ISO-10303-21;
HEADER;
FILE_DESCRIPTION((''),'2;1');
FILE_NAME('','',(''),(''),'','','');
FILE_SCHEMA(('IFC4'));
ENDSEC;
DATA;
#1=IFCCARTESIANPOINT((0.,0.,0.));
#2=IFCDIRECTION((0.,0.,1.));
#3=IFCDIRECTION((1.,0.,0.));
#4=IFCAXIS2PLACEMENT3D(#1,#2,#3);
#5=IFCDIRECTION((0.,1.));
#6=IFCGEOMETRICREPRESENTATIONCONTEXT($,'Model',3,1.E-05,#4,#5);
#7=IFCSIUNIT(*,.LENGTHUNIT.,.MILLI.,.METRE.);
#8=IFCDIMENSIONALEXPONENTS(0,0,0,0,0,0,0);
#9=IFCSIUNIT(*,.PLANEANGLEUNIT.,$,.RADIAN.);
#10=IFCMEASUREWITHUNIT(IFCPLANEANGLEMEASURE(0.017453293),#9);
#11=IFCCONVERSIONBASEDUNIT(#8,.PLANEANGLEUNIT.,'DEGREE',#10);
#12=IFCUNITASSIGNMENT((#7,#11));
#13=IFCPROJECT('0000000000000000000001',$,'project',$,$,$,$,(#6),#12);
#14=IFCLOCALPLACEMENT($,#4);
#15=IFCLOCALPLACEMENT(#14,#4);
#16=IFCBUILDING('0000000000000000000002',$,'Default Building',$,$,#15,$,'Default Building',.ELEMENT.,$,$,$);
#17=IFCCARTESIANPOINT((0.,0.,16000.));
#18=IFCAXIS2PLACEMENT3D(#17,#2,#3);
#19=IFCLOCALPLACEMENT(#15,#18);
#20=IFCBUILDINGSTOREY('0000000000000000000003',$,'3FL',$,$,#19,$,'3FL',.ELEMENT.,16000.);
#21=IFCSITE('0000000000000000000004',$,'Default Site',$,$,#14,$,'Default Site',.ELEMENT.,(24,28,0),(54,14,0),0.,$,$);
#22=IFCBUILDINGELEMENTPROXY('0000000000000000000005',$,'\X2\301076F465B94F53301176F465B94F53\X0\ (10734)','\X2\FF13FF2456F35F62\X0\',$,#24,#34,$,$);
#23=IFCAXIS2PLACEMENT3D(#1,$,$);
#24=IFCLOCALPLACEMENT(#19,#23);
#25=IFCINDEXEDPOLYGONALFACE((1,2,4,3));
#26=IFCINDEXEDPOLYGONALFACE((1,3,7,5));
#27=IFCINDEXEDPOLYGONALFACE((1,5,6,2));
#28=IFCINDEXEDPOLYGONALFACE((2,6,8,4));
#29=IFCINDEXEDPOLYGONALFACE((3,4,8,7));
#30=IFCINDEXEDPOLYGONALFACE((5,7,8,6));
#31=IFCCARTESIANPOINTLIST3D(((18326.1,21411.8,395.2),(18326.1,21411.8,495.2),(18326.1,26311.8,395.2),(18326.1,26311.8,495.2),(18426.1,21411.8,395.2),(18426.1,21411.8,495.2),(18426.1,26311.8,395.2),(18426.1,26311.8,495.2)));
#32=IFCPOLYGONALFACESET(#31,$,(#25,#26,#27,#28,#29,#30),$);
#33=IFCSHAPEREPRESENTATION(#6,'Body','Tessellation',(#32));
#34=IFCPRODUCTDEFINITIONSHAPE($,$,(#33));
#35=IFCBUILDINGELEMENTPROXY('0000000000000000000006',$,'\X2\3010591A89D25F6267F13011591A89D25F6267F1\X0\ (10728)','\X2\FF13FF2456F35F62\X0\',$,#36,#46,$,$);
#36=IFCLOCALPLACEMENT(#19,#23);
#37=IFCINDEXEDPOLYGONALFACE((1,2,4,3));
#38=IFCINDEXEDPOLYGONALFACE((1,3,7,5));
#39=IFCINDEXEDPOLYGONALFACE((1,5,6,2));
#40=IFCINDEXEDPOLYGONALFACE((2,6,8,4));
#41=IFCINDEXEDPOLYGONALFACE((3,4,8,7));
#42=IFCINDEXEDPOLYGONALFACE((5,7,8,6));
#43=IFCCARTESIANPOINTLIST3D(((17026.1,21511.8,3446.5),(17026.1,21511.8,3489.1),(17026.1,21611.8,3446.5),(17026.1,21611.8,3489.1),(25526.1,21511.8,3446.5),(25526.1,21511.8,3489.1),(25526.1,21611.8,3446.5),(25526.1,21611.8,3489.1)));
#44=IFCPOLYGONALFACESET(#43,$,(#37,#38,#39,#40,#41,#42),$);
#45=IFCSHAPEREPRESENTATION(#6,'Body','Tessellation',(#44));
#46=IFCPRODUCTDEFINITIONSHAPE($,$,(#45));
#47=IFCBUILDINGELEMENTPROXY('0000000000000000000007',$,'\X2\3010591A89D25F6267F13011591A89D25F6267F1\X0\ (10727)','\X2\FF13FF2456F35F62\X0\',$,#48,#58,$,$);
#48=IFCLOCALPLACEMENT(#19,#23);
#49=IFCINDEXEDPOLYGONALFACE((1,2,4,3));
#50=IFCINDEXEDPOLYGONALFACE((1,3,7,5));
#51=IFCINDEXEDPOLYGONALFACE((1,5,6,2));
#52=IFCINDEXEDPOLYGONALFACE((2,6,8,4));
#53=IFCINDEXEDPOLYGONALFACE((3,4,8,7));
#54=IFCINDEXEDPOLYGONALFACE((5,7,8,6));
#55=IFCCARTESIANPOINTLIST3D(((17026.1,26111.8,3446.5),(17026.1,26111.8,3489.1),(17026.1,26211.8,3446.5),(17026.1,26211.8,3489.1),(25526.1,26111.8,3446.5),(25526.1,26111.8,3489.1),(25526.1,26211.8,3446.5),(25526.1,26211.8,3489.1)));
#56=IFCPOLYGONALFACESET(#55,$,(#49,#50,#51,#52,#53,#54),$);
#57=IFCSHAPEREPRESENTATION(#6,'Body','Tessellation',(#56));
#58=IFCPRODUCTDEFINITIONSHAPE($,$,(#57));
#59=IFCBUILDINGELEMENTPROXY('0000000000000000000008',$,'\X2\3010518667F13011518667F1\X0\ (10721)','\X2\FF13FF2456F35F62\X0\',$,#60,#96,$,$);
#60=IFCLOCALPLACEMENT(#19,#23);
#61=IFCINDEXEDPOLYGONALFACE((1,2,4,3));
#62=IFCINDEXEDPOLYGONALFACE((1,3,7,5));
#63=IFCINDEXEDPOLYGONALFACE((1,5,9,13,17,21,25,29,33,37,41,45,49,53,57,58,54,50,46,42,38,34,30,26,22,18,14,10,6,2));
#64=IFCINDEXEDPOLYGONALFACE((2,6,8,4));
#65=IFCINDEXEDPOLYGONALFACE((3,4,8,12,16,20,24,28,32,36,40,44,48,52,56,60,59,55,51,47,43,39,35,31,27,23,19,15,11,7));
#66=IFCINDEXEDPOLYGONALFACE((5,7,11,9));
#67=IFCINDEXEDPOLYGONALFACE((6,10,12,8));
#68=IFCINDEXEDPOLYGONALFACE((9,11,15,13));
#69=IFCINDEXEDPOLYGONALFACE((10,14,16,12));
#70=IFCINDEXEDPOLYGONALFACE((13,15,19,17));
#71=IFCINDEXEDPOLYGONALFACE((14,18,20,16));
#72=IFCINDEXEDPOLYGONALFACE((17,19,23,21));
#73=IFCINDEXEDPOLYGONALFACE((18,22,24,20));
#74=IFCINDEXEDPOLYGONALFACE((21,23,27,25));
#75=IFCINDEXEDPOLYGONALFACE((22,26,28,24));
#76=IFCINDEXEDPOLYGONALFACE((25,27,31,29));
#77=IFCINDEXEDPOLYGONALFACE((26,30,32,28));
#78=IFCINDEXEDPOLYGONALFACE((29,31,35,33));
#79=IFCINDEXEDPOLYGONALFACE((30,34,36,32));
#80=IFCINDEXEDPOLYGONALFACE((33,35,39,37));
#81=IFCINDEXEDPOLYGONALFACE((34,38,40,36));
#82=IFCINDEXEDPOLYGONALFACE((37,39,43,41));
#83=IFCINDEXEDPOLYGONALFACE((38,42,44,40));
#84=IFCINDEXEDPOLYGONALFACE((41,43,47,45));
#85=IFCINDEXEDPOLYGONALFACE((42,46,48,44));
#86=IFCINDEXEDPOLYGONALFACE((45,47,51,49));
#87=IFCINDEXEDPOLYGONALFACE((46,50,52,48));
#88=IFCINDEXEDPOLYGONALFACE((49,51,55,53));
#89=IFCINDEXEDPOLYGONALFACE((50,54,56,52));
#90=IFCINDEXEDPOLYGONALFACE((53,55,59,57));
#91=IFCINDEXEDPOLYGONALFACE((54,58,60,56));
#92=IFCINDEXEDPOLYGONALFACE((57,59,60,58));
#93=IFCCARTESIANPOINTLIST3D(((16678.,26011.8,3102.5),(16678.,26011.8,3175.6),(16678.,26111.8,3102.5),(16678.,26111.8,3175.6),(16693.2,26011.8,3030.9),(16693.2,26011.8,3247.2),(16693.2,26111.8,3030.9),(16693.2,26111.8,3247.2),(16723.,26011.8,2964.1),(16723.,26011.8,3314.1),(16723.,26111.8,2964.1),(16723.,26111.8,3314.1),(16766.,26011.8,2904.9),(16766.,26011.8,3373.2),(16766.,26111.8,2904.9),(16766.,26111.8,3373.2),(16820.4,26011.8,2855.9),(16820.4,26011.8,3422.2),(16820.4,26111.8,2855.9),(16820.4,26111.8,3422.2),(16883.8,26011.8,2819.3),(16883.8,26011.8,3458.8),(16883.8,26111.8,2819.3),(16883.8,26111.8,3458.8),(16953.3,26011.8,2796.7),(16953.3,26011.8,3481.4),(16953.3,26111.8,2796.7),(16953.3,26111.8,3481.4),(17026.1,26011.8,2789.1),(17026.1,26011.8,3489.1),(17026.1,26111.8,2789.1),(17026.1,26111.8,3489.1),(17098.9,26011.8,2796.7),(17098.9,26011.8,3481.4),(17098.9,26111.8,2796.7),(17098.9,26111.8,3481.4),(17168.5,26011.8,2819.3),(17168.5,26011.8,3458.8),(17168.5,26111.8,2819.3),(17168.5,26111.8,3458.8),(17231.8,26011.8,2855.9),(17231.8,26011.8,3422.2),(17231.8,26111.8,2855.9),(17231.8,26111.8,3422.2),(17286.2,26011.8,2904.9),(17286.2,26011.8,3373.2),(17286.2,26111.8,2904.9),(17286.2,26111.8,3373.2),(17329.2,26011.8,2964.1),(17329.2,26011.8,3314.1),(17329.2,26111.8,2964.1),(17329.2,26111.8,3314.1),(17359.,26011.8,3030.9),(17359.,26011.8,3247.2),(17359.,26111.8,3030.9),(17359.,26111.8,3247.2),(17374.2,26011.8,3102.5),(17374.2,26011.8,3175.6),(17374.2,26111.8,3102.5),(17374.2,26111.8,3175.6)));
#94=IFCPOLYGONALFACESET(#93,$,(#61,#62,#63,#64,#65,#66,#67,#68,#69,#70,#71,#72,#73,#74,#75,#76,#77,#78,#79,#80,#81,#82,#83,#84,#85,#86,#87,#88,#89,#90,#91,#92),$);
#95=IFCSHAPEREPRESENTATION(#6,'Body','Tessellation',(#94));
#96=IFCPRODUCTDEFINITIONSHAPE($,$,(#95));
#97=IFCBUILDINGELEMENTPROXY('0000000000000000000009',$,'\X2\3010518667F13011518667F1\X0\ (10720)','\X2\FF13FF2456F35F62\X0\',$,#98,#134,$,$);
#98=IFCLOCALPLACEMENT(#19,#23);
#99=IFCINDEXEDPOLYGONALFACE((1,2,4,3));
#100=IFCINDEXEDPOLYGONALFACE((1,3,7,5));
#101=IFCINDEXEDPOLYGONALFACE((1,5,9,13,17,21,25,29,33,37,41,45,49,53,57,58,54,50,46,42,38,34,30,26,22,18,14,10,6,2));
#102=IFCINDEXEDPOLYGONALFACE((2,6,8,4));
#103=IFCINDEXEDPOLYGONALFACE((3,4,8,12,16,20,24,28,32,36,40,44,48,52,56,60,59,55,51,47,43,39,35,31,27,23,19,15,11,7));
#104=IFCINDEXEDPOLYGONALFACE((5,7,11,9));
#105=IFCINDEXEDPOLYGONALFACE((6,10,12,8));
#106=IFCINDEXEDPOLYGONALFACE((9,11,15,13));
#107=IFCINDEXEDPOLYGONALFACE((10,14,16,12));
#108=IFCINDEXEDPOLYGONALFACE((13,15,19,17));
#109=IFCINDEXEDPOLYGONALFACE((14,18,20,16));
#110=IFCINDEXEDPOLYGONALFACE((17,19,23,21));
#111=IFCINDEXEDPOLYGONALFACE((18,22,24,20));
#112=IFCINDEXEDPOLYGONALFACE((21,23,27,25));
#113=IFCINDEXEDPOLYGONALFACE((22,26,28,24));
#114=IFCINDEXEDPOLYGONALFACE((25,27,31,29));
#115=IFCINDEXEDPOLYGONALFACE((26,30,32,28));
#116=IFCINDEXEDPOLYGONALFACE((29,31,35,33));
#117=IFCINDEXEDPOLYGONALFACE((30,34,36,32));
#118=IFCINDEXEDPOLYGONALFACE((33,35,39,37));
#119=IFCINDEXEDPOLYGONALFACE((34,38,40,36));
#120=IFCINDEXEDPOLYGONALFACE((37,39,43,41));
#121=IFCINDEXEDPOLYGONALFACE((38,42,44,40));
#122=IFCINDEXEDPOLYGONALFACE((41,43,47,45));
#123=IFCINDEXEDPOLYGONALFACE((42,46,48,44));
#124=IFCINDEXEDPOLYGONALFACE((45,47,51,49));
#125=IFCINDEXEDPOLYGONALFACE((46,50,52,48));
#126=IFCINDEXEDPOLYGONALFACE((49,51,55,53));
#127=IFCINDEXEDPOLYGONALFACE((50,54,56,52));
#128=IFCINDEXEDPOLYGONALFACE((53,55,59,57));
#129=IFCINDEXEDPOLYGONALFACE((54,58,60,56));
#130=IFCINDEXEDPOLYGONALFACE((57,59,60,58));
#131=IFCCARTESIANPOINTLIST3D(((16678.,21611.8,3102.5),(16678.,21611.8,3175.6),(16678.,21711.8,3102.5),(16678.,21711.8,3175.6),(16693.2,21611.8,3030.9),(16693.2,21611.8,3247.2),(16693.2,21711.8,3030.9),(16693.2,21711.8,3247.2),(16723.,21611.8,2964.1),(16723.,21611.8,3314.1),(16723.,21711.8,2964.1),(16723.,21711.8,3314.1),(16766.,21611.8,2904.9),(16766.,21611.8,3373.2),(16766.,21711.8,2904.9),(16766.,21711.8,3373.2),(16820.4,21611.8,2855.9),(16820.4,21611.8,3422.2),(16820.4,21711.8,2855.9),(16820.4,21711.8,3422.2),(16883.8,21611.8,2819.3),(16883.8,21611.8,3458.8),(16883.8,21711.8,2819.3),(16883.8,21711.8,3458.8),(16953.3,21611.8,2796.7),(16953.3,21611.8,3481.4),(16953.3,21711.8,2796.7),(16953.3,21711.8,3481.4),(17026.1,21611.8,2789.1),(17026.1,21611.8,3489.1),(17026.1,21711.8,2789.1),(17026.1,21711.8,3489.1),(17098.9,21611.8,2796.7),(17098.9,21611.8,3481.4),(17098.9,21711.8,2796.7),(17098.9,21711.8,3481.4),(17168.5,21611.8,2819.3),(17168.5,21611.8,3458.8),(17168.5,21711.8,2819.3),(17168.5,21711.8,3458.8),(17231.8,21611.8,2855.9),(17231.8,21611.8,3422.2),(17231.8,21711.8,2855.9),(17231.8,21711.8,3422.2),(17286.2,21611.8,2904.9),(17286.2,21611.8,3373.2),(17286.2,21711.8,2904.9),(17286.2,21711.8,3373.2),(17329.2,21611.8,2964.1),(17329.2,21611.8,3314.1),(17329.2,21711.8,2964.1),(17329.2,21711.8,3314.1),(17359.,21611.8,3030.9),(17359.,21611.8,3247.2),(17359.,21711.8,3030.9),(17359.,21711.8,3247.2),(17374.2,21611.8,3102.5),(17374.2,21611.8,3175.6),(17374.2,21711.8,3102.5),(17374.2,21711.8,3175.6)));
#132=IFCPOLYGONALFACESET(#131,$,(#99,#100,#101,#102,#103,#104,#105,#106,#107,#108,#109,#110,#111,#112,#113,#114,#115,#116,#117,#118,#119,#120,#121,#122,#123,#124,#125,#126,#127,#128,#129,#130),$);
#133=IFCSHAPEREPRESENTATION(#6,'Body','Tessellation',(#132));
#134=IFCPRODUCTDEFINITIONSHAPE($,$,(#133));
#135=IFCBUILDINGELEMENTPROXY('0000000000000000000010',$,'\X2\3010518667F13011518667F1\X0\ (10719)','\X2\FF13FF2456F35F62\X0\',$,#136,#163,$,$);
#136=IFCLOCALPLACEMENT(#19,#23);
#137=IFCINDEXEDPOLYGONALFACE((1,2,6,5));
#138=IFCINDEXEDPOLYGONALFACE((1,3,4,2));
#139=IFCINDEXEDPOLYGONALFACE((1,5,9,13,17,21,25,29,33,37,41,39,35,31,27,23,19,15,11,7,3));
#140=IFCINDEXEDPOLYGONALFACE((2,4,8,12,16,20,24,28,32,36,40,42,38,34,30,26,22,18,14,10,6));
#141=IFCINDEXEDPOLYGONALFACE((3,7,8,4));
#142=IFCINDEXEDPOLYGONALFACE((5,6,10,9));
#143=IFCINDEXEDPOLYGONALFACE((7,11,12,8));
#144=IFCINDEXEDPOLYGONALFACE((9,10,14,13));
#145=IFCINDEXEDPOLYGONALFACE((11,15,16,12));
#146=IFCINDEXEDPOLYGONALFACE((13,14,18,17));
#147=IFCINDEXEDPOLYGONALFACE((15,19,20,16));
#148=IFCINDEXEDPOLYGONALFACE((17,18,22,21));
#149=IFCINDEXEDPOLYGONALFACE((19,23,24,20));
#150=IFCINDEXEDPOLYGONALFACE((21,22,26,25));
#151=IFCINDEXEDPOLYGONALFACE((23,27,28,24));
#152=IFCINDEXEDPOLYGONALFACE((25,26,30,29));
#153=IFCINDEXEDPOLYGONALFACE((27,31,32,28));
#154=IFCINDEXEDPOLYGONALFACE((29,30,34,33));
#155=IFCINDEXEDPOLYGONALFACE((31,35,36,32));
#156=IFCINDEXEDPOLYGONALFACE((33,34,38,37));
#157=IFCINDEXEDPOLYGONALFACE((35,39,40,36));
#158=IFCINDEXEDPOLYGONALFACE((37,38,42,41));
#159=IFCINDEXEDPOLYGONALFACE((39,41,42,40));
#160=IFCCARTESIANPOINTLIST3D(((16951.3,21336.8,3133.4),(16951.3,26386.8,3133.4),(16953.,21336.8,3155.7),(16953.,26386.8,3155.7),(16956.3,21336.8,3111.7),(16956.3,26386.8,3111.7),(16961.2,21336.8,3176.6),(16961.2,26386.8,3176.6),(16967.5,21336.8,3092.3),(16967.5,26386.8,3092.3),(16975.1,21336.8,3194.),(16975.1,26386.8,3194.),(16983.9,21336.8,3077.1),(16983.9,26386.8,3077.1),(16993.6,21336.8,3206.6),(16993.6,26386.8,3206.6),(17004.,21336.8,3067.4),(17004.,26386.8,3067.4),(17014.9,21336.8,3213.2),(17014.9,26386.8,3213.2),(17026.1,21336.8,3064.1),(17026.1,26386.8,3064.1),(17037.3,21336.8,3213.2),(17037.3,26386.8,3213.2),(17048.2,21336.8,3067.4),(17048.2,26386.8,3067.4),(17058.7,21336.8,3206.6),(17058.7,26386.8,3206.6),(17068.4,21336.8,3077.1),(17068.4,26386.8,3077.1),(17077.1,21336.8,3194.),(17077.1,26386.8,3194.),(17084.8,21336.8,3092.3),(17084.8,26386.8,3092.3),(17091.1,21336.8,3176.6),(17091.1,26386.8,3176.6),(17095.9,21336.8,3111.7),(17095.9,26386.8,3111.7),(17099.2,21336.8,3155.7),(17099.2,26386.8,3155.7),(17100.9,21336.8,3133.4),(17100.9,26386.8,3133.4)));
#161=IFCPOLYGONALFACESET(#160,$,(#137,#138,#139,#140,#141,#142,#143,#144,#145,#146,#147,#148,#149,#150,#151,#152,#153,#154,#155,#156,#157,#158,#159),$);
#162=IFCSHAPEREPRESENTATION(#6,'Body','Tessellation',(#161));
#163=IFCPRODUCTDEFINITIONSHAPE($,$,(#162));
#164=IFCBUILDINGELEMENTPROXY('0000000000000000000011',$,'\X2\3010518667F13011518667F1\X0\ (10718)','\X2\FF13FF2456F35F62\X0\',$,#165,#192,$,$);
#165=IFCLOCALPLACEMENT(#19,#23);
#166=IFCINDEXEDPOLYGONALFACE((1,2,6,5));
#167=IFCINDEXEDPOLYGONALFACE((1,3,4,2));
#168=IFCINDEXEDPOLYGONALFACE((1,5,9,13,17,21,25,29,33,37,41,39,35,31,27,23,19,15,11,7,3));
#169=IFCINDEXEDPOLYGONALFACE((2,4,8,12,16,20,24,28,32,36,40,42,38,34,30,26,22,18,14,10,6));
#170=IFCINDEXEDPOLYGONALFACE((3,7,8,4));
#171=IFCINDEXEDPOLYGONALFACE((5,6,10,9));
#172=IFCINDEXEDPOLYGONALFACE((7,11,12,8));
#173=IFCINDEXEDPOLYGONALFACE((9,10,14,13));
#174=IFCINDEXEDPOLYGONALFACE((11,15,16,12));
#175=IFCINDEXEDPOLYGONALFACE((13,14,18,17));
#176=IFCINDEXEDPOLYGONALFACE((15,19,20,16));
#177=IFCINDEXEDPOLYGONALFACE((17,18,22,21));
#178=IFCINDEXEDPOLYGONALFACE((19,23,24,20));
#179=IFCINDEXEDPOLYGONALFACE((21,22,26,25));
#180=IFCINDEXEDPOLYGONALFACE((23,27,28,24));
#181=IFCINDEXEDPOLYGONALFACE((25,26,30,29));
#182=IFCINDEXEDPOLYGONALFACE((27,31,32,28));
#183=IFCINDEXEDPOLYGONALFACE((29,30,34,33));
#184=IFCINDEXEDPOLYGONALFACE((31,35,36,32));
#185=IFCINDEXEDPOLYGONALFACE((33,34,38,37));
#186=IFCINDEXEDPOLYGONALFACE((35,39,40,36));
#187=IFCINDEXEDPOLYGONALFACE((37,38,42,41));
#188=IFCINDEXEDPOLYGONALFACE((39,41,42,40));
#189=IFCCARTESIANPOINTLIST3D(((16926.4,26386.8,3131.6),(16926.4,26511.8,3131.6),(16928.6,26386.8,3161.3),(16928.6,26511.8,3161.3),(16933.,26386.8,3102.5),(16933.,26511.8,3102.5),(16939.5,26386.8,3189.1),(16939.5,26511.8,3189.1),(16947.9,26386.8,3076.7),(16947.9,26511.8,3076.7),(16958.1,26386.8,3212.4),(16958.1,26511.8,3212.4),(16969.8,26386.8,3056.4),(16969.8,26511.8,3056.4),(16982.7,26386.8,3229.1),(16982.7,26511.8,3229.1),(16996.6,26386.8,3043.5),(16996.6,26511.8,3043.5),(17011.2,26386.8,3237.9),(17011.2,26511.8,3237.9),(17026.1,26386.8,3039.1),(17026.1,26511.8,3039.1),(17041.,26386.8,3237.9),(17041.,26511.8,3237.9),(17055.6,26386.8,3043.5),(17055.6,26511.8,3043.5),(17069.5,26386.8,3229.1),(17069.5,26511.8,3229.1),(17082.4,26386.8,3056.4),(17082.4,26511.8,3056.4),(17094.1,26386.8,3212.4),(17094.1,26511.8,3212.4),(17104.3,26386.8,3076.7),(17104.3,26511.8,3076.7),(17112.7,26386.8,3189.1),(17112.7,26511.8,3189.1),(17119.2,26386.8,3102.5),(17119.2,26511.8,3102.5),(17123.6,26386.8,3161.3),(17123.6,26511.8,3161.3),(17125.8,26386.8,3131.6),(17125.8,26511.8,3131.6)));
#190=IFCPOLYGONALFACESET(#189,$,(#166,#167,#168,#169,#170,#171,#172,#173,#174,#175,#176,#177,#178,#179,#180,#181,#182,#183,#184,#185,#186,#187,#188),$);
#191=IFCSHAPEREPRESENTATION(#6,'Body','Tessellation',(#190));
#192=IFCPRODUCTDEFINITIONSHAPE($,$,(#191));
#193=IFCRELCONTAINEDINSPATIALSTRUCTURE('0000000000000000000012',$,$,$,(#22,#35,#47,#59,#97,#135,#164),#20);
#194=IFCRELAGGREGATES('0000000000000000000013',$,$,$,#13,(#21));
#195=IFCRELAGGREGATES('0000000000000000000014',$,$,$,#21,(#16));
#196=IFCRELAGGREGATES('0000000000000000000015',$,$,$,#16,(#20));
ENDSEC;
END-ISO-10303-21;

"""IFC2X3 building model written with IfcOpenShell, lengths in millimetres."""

from ifc_helpers import new_model, entity, si_unit, converted_unit, direction, frame, origin_with_axes, origin_2d_with_axis, place, context, project, spatial, polyline, rectangle, circle, outline, extrude, source, transform, mapped, element, save


model = new_model("IFC2X3")

# Units and contexts
model_context = context("Model", 3, precision=1e-05, world=origin_with_axes(), true_north=direction((0.0, 1.0)))
ifc_project = project(units=[si_unit("LENGTHUNIT", "METRE", prefix="MILLI"), converted_unit("PLANEANGLEUNIT", "DEGREE", entity("IfcPlaneAngleMeasure", 0.017453293), si_unit("PLANEANGLEUNIT", "RADIAN"), dimensions=[0, 0, 0, 0, 0, 0, 0])], contexts=[model_context])

# Site, building, storey
site_placement = place(None, origin_with_axes())
site = spatial("IfcSite", under=ifc_project, at=site_placement, Name="Default Site", LongName="Default Site", CompositionType="ELEMENT", RefLatitude=(24, 28, 0), RefLongitude=(54, 14, 0), RefElevation=0.0)
building_placement = place(site_placement, origin_with_axes())
building = spatial("IfcBuilding", under=site, at=building_placement, Name="Default Building", LongName="Default Building", CompositionType="ELEMENT")
storey_placement = place(building_placement, frame((0.0, 0.0, 16000.0), z_axis=(0.0, 0.0, 1.0), x_axis=(1.0, 0.0, 0.0)))
storey = spatial("IfcBuildingStorey", under=building, at=storey_placement, Name="3FL", LongName="3FL", CompositionType="ELEMENT", Elevation=16000.0)

# Building element proxies
shared_shape_1 = source(origin_with_axes(), model_context, "Body", "SweptSolid", [
    extrude(rectangle(XDim=100.0, YDim=4900.0, at=origin_2d_with_axis()), origin_with_axes(), (0.0, 0.0, 1.0), 100.0),
])
proxy_1_placement = place(storey_placement, frame((18376.1, 23861.8, 395.2), z_axis=(0.0, 0.0, 1.0), x_axis=(1.0, 0.0, 0.0)))
element("IfcBuildingElementProxy", 1, at=proxy_1_placement, inside=storey, Name="【直方体】直方体 (10734)", Description="３Ｄ図形", context=model_context, shape_type="MappedRepresentation", body=[
    mapped(shared_shape_1, transform((0.0, 0.0, 0.0))),
])
shared_shape_2 = source(origin_with_axes(), model_context, "Body", "SweptSolid", [
    extrude(outline(polyline([(-4250.0, -21.3), (4250.0, -21.3), (4250.0, 21.3), (-4250.0, 21.3), (-4250.0, -21.3)])), origin_with_axes(), (0.0, 0.0, 1.0), 100.0),
])
proxy_2_placement = place(storey_placement, frame((21276.1, 21611.8, 3467.8), z_axis=(0.0, -1.0, 0.0), x_axis=(1.0, 0.0, 0.0)))
element("IfcBuildingElementProxy", 2, at=proxy_2_placement, inside=storey, Name="【多角形柱】多角形柱 (10728)", Description="３Ｄ図形", context=model_context, shape_type="MappedRepresentation", body=[
    mapped(shared_shape_2, transform((0.0, 0.0, 0.0))),
])
shared_shape_3 = source(origin_with_axes(), model_context, "Body", "SweptSolid", [
    extrude(outline(polyline([(-4250.0, -21.3), (4250.0, -21.3), (4250.0, 21.3), (-4250.0, 21.3), (-4250.0, -21.3)])), origin_with_axes(), (0.0, 0.0, 1.0), 100.0),
])
proxy_3_placement = place(storey_placement, frame((21276.1, 26211.8, 3467.8), z_axis=(0.0, -1.0, 0.0), x_axis=(1.0, 0.0, 0.0)))
element("IfcBuildingElementProxy", 3, at=proxy_3_placement, inside=storey, Name="【多角形柱】多角形柱 (10727)", Description="３Ｄ図形", context=model_context, shape_type="MappedRepresentation", body=[
    mapped(shared_shape_3, transform((0.0, 0.0, 0.0))),
])
shared_shape_4 = source(origin_with_axes(), model_context, "Body", "SweptSolid", [
    extrude(circle(Radius=350.0, at=origin_2d_with_axis()), frame((0.0, 0.0, 0.0), z_axis=(0.0, 0.0, 1.0), x_axis=(1.0, 0.0, 0.0)), (0.0, 0.0, 1.0), 100.0),
])
proxy_4_placement = place(storey_placement, frame((17026.1, 26011.8, 3139.1), z_axis=(0.0, 1.0, 0.0), x_axis=(0.0, 0.0, -1.0)))
element("IfcBuildingElementProxy", 4, at=proxy_4_placement, inside=storey, Name="【円柱】円柱 (10721)", Description="３Ｄ図形", context=model_context, shape_type="MappedRepresentation", body=[
    mapped(shared_shape_4, transform((0.0, 0.0, 0.0))),
])
shared_shape_5 = source(origin_with_axes(), model_context, "Body", "SweptSolid", [
    extrude(circle(Radius=350.0, at=origin_2d_with_axis()), frame((0.0, 0.0, 0.0), z_axis=(0.0, 0.0, 1.0), x_axis=(1.0, 0.0, 0.0)), (0.0, 0.0, 1.0), 100.0),
])
proxy_5_placement = place(storey_placement, frame((17026.1, 21611.8, 3139.1), z_axis=(0.0, 1.0, 0.0), x_axis=(0.0, 0.0, -1.0)))
element("IfcBuildingElementProxy", 5, at=proxy_5_placement, inside=storey, Name="【円柱】円柱 (10720)", Description="３Ｄ図形", context=model_context, shape_type="MappedRepresentation", body=[
    mapped(shared_shape_5, transform((0.0, 0.0, 0.0))),
])
shared_shape_6 = source(origin_with_axes(), model_context, "Body", "SweptSolid", [
    extrude(circle(Radius=75.0, at=origin_2d_with_axis()), frame((0.0, 0.0, 0.0), z_axis=(0.0, 0.0, 1.0), x_axis=(1.0, 0.0, 0.0)), (0.0, 0.0, 1.0), 5050.0),
])
proxy_6_placement = place(storey_placement, frame((17026.1, 21336.8, 3139.1), z_axis=(0.0, 1.0, 0.0), x_axis=(0.0, 0.0, -1.0)))
element("IfcBuildingElementProxy", 6, at=proxy_6_placement, inside=storey, Name="【円柱】円柱 (10719)", Description="３Ｄ図形", context=model_context, shape_type="MappedRepresentation", body=[
    mapped(shared_shape_6, transform((0.0, 0.0, 0.0))),
])
shared_shape_7 = source(origin_with_axes(), model_context, "Body", "SweptSolid", [
    extrude(circle(Radius=100.0, at=origin_2d_with_axis()), frame((0.0, 0.0, 0.0), z_axis=(0.0, 0.0, 1.0), x_axis=(1.0, 0.0, 0.0)), (0.0, 0.0, 1.0), 125.0),
])
proxy_7_placement = place(storey_placement, frame((17026.1, 26386.8, 3139.1), z_axis=(0.0, 1.0, 0.0), x_axis=(0.0, 0.0, -1.0)))
element("IfcBuildingElementProxy", 7, at=proxy_7_placement, inside=storey, Name="【円柱】円柱 (10718)", Description="３Ｄ図形", context=model_context, shape_type="MappedRepresentation", body=[
    mapped(shared_shape_7, transform((0.0, 0.0, 0.0))),
])

save(model, "model.ifc")
